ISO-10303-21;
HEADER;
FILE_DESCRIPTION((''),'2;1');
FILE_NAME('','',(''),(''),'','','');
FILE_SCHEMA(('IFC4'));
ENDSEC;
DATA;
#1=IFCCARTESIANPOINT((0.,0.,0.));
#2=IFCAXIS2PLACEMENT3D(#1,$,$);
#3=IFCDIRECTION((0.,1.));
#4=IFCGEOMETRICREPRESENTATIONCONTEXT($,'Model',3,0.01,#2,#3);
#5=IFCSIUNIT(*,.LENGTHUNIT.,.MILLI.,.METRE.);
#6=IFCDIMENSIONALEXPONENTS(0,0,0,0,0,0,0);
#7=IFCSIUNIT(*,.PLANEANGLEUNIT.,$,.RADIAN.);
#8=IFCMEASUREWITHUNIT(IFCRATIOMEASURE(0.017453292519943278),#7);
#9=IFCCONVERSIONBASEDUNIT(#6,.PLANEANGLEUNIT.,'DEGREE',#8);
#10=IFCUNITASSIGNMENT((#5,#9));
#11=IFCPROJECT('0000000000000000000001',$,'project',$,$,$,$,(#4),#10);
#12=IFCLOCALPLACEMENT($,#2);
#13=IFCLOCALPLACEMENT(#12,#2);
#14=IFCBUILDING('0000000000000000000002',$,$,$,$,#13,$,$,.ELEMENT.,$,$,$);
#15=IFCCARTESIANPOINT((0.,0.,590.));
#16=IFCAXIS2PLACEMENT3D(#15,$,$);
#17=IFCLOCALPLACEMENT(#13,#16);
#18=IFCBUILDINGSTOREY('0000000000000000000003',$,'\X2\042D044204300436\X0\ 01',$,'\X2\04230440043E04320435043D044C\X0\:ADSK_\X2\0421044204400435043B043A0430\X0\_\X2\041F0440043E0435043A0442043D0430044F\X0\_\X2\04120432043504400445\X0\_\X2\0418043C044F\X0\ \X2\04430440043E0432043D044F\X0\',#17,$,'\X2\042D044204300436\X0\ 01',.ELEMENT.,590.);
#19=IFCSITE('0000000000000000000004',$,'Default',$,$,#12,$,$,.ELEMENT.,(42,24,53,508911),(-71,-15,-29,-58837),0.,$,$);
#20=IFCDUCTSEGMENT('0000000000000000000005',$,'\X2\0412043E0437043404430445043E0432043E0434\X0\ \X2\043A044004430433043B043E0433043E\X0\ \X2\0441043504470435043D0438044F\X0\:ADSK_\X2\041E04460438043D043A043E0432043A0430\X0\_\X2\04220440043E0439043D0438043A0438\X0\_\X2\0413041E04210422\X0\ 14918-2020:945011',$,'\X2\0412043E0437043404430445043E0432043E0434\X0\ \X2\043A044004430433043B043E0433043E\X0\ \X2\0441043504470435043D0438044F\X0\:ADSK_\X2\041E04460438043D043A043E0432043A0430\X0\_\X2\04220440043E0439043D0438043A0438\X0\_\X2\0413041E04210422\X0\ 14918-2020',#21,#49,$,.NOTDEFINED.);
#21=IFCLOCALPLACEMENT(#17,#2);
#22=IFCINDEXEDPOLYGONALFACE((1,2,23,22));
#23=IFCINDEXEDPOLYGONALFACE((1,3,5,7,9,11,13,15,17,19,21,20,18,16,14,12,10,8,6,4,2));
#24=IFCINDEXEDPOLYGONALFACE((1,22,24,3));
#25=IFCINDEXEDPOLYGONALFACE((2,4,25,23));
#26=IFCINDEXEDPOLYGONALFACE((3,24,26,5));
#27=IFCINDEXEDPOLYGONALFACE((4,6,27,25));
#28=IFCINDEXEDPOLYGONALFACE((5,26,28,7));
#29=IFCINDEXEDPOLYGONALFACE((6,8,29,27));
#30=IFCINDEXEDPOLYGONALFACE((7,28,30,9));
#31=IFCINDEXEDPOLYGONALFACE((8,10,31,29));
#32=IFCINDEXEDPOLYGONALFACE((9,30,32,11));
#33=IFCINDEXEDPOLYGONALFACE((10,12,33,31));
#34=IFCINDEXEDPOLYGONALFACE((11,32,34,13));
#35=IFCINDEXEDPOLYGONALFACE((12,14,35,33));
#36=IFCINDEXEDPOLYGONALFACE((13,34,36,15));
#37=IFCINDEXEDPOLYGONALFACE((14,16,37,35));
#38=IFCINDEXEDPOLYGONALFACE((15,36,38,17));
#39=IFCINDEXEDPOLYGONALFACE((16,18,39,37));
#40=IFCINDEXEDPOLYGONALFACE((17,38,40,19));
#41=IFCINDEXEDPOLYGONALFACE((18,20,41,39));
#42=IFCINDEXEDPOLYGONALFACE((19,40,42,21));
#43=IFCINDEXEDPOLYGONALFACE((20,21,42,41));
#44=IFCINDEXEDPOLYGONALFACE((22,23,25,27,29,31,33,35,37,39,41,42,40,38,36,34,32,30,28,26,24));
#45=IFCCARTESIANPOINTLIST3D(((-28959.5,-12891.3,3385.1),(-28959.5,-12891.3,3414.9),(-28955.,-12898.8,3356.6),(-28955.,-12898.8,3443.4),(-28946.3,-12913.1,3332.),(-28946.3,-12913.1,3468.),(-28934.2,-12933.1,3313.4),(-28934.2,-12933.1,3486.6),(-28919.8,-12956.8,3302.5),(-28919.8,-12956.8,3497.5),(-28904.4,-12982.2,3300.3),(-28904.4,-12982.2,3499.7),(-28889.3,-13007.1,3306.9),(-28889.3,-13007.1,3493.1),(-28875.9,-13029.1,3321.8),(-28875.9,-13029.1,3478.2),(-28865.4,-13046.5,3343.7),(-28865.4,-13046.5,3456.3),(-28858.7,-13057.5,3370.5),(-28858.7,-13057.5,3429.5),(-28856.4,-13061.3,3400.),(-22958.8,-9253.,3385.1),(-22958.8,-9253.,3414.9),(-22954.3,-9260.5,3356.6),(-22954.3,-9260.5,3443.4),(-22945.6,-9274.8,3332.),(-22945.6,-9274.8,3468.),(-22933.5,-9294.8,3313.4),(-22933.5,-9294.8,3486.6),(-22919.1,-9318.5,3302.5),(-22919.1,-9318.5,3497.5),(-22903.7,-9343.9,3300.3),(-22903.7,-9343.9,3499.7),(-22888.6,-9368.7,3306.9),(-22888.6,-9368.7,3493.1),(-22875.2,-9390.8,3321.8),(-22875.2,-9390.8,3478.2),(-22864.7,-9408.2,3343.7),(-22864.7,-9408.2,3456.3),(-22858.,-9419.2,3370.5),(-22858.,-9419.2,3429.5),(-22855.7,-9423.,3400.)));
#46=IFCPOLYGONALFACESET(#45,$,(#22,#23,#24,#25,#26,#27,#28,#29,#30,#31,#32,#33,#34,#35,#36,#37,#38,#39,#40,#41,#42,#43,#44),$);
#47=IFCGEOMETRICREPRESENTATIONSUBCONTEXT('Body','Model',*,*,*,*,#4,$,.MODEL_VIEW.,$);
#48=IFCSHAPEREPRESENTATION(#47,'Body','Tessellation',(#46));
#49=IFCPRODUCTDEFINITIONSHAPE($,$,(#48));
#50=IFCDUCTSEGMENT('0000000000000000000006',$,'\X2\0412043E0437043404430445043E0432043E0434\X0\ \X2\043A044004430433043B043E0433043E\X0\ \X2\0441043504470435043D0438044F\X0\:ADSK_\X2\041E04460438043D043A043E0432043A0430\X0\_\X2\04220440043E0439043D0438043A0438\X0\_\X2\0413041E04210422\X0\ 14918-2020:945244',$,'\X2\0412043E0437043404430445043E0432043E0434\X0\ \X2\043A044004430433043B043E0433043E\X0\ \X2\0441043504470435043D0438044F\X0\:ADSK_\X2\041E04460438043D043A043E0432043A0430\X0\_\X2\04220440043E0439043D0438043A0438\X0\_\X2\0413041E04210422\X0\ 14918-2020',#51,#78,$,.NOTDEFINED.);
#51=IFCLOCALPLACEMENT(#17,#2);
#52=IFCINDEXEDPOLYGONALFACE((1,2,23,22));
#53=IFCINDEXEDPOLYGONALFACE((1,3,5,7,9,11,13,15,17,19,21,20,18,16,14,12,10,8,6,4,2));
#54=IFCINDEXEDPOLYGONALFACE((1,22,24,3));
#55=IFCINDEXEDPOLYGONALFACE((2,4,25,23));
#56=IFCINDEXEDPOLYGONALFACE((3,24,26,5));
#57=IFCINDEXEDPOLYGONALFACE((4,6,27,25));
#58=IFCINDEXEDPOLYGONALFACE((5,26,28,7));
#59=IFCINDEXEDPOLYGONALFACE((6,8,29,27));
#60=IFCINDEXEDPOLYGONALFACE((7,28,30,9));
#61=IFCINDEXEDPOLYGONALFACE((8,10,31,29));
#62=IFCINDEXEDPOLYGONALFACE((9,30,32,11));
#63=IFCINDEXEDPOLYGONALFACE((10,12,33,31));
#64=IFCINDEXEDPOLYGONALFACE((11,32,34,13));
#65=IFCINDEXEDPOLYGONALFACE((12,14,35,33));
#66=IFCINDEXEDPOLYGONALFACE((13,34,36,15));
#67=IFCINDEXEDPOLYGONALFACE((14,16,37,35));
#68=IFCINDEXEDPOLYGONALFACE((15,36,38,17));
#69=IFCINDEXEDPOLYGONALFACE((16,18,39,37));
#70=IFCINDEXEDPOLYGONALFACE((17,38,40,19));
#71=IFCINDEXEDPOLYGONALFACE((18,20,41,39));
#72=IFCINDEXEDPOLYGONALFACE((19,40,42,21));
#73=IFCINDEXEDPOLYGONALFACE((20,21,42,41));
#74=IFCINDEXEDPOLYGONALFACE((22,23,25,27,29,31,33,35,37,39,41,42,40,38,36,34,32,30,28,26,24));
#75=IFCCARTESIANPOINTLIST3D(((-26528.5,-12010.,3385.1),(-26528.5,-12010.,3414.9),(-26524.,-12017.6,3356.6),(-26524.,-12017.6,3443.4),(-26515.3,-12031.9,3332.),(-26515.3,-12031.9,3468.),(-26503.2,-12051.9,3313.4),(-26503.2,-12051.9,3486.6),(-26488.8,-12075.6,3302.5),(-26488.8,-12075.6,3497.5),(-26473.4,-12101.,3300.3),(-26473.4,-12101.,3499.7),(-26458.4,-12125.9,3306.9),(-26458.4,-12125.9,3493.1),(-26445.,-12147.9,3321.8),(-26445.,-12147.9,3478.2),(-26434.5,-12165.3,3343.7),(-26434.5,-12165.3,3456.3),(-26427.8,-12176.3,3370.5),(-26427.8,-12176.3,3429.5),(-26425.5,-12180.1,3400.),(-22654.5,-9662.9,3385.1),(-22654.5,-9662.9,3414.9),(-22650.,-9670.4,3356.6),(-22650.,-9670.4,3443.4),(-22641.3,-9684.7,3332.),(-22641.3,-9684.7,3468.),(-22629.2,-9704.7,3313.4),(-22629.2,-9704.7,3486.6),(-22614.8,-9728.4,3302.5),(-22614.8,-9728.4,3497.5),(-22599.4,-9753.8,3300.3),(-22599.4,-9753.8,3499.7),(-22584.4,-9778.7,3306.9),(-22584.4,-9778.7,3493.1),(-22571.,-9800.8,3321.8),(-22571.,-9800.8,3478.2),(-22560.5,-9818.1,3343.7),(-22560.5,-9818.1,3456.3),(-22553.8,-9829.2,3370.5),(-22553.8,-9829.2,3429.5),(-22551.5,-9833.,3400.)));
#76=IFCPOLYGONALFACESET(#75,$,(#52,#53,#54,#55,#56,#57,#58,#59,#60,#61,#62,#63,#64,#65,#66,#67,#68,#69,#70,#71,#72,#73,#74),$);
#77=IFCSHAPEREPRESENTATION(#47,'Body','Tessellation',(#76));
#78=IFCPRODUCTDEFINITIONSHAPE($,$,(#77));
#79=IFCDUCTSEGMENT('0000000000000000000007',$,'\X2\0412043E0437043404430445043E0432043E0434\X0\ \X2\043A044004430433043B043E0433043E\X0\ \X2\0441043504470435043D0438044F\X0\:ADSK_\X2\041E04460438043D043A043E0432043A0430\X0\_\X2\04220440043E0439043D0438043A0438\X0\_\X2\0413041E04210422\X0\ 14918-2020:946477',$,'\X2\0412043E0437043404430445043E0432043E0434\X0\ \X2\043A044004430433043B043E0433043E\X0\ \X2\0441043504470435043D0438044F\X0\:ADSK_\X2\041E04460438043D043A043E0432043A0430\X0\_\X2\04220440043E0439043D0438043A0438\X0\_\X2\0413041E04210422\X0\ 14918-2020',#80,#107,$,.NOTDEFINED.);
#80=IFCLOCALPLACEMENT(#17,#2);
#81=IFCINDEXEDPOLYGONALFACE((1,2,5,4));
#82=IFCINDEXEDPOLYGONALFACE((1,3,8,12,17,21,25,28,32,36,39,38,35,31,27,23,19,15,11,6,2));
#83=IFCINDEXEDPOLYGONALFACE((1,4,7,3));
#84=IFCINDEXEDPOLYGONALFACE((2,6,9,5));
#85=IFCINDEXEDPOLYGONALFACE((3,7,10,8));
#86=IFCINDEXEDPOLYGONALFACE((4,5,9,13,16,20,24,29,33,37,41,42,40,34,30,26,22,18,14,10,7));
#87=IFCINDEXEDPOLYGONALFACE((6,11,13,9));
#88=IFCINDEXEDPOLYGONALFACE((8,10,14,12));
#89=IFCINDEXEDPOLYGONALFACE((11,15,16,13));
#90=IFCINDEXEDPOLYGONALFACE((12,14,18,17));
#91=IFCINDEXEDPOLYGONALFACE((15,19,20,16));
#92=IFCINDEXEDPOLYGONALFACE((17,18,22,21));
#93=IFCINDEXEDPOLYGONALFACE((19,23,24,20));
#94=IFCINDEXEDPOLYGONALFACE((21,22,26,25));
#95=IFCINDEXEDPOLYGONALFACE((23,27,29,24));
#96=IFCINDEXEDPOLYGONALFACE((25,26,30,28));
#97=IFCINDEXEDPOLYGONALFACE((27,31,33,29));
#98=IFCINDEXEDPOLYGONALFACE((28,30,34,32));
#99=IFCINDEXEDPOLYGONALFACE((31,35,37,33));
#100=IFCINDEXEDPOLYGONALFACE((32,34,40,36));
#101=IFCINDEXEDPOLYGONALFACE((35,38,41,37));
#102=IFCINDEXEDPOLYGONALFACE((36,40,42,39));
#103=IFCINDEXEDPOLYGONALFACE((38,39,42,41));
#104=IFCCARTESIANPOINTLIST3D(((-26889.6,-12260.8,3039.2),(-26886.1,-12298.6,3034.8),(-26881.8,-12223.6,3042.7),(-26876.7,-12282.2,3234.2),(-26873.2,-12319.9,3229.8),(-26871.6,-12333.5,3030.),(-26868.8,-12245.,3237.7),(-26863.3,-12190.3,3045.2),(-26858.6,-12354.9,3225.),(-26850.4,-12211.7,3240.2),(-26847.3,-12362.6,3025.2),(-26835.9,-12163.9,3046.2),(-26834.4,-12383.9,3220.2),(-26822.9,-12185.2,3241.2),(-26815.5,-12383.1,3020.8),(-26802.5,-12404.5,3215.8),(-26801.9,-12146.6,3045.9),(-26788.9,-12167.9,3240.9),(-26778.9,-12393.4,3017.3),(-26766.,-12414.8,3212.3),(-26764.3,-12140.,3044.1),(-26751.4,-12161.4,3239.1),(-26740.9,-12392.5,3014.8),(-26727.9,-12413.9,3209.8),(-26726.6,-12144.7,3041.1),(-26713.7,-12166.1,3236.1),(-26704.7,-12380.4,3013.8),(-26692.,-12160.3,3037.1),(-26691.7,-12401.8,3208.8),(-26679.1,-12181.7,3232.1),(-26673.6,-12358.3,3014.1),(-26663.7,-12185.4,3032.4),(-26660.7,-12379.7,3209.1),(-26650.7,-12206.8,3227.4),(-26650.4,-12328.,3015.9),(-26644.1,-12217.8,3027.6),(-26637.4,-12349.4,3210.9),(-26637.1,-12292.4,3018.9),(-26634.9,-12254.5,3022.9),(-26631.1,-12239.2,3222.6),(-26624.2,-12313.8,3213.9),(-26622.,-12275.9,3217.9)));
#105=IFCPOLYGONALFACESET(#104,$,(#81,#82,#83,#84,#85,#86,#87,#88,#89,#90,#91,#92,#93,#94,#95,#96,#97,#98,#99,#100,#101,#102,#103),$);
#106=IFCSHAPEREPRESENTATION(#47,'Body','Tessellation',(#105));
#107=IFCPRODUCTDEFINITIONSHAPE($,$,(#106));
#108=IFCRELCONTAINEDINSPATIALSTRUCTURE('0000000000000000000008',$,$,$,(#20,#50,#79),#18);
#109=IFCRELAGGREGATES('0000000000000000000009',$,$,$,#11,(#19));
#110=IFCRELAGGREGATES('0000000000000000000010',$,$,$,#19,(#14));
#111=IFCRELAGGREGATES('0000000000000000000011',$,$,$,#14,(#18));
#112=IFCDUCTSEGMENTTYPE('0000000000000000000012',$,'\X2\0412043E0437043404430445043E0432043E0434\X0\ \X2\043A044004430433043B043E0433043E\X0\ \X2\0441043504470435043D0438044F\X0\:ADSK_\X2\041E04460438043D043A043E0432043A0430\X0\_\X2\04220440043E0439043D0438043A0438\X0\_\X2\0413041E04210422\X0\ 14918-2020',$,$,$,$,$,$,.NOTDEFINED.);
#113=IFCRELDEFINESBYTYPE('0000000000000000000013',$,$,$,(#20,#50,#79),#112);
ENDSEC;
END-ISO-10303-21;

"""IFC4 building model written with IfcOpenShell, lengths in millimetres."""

from ifc_helpers import new_model, entity, si_unit, converted_unit, direction, frame, frame_2d, origin, origin_2d_with_axis, place, context, subcontext, project, spatial, circle, extrude, type_object, element, save


model = new_model("IFC4")

# Units and contexts
model_context = context("Model", 3, precision=0.01, world=origin(), true_north=direction((0.0, 1.0)))
body_context = subcontext(model_context, "Body", "Model", "MODEL_VIEW")
ifc_project = project(units=[si_unit("LENGTHUNIT", "METRE", prefix="MILLI"), converted_unit("PLANEANGLEUNIT", "DEGREE", entity("IfcRatioMeasure", 0.017453292519943278), si_unit("PLANEANGLEUNIT", "RADIAN"), dimensions=[0, 0, 0, 0, 0, 0, 0])], contexts=[model_context])

# Site, building, storey
site_placement = place(None, origin())
site = spatial("IfcSite", under=ifc_project, at=site_placement, Name="Default", CompositionType="ELEMENT", RefLatitude=(42, 24, 53, 508911), RefLongitude=(-71, -15, -29, -58837), RefElevation=0.0)
building_placement = place(site_placement, origin())
building = spatial("IfcBuilding", under=site, at=building_placement, CompositionType="ELEMENT")
storey_placement = place(building_placement, frame((0.0, 0.0, 590.0)))
storey = spatial("IfcBuildingStorey", under=building, at=storey_placement, Name="Этаж 01", ObjectType="Уровень:ADSK_Стрелка_Проектная_Вверх_Имя уровня", LongName="Этаж 01", CompositionType="ELEMENT", Elevation=590.0)

# Duct segments
duct_segment_type = type_object("IfcDuctSegmentType", Name="Воздуховод круглого сечения:ADSK_Оцинковка_Тройники_ГОСТ 14918-2020", PredefinedType="NOTDEFINED")
duct_segment_1_placement = place(storey_placement, frame((-28961.7, -13062.9, 3501.6)))
element("IfcDuctSegment", 1, at=duct_segment_1_placement, inside=storey, type_object=duct_segment_type, Name="Воздуховод круглого сечения:ADSK_Оцинковка_Тройники_ГОСТ 14918-2020:945011", ObjectType="Воздуховод круглого сечения:ADSK_Оцинковка_Тройники_ГОСТ 14918-2020", PredefinedType="NOTDEFINED", context=body_context, shape_type="SweptSolid", body=[
    extrude(circle(Radius=100.0, at=origin_2d_with_axis()), frame((53.4, 87.1, -101.6), z_axis=(0.855102, 0.51846, 0.0), x_axis=(0.51846, -0.855102, 0.0)), (0.0, 0.0, 1.0), 7017.5),
])
duct_segment_2_placement = place(storey_placement, frame((-26530.7, -12181.7, 3298.4)))
element("IfcDuctSegment", 2, at=duct_segment_2_placement, inside=storey, type_object=duct_segment_type, Name="Воздуховод круглого сечения:ADSK_Оцинковка_Тройники_ГОСТ 14918-2020:945244", ObjectType="Воздуховод круглого сечения:ADSK_Оцинковка_Тройники_ГОСТ 14918-2020", PredefinedType="NOTDEFINED", context=body_context, shape_type="SweptSolid", body=[
    extrude(circle(Radius=100.0, at=origin_2d_with_axis()), frame((53.4, 87.1, 101.6), z_axis=(0.855267, 0.518188, 0.0), x_axis=(0.518188, -0.855267, 0.0)), (0.0, 0.0, 1.0), 4529.6),
])
duct_segment_3_placement = place(storey_placement, frame((-26891.4, -12417.4, 3012.1)))
element("IfcDuctSegment", 3, at=duct_segment_3_placement, inside=storey, type_object=duct_segment_type, Name="Воздуховод круглого сечения:ADSK_Оцинковка_Тройники_ГОСТ 14918-2020:946477", ObjectType="Воздуховод круглого сечения:ADSK_Оцинковка_Тройники_ГОСТ 14918-2020", PredefinedType="NOTDEFINED", context=body_context, shape_type="SweptSolid", body=[
    extrude(circle(Radius=128.0, at=frame_2d((0.0, 0.0), x_axis=(1.0, 0.0))), frame((129.3, 150.2, 17.9), z_axis=(0.065895, -0.108759, 0.991882), x_axis=(-0.855267, -0.518188, 0.0)), (0.0, 0.0, 1.0), 196.6),
])

save(model, "model.ifc")
